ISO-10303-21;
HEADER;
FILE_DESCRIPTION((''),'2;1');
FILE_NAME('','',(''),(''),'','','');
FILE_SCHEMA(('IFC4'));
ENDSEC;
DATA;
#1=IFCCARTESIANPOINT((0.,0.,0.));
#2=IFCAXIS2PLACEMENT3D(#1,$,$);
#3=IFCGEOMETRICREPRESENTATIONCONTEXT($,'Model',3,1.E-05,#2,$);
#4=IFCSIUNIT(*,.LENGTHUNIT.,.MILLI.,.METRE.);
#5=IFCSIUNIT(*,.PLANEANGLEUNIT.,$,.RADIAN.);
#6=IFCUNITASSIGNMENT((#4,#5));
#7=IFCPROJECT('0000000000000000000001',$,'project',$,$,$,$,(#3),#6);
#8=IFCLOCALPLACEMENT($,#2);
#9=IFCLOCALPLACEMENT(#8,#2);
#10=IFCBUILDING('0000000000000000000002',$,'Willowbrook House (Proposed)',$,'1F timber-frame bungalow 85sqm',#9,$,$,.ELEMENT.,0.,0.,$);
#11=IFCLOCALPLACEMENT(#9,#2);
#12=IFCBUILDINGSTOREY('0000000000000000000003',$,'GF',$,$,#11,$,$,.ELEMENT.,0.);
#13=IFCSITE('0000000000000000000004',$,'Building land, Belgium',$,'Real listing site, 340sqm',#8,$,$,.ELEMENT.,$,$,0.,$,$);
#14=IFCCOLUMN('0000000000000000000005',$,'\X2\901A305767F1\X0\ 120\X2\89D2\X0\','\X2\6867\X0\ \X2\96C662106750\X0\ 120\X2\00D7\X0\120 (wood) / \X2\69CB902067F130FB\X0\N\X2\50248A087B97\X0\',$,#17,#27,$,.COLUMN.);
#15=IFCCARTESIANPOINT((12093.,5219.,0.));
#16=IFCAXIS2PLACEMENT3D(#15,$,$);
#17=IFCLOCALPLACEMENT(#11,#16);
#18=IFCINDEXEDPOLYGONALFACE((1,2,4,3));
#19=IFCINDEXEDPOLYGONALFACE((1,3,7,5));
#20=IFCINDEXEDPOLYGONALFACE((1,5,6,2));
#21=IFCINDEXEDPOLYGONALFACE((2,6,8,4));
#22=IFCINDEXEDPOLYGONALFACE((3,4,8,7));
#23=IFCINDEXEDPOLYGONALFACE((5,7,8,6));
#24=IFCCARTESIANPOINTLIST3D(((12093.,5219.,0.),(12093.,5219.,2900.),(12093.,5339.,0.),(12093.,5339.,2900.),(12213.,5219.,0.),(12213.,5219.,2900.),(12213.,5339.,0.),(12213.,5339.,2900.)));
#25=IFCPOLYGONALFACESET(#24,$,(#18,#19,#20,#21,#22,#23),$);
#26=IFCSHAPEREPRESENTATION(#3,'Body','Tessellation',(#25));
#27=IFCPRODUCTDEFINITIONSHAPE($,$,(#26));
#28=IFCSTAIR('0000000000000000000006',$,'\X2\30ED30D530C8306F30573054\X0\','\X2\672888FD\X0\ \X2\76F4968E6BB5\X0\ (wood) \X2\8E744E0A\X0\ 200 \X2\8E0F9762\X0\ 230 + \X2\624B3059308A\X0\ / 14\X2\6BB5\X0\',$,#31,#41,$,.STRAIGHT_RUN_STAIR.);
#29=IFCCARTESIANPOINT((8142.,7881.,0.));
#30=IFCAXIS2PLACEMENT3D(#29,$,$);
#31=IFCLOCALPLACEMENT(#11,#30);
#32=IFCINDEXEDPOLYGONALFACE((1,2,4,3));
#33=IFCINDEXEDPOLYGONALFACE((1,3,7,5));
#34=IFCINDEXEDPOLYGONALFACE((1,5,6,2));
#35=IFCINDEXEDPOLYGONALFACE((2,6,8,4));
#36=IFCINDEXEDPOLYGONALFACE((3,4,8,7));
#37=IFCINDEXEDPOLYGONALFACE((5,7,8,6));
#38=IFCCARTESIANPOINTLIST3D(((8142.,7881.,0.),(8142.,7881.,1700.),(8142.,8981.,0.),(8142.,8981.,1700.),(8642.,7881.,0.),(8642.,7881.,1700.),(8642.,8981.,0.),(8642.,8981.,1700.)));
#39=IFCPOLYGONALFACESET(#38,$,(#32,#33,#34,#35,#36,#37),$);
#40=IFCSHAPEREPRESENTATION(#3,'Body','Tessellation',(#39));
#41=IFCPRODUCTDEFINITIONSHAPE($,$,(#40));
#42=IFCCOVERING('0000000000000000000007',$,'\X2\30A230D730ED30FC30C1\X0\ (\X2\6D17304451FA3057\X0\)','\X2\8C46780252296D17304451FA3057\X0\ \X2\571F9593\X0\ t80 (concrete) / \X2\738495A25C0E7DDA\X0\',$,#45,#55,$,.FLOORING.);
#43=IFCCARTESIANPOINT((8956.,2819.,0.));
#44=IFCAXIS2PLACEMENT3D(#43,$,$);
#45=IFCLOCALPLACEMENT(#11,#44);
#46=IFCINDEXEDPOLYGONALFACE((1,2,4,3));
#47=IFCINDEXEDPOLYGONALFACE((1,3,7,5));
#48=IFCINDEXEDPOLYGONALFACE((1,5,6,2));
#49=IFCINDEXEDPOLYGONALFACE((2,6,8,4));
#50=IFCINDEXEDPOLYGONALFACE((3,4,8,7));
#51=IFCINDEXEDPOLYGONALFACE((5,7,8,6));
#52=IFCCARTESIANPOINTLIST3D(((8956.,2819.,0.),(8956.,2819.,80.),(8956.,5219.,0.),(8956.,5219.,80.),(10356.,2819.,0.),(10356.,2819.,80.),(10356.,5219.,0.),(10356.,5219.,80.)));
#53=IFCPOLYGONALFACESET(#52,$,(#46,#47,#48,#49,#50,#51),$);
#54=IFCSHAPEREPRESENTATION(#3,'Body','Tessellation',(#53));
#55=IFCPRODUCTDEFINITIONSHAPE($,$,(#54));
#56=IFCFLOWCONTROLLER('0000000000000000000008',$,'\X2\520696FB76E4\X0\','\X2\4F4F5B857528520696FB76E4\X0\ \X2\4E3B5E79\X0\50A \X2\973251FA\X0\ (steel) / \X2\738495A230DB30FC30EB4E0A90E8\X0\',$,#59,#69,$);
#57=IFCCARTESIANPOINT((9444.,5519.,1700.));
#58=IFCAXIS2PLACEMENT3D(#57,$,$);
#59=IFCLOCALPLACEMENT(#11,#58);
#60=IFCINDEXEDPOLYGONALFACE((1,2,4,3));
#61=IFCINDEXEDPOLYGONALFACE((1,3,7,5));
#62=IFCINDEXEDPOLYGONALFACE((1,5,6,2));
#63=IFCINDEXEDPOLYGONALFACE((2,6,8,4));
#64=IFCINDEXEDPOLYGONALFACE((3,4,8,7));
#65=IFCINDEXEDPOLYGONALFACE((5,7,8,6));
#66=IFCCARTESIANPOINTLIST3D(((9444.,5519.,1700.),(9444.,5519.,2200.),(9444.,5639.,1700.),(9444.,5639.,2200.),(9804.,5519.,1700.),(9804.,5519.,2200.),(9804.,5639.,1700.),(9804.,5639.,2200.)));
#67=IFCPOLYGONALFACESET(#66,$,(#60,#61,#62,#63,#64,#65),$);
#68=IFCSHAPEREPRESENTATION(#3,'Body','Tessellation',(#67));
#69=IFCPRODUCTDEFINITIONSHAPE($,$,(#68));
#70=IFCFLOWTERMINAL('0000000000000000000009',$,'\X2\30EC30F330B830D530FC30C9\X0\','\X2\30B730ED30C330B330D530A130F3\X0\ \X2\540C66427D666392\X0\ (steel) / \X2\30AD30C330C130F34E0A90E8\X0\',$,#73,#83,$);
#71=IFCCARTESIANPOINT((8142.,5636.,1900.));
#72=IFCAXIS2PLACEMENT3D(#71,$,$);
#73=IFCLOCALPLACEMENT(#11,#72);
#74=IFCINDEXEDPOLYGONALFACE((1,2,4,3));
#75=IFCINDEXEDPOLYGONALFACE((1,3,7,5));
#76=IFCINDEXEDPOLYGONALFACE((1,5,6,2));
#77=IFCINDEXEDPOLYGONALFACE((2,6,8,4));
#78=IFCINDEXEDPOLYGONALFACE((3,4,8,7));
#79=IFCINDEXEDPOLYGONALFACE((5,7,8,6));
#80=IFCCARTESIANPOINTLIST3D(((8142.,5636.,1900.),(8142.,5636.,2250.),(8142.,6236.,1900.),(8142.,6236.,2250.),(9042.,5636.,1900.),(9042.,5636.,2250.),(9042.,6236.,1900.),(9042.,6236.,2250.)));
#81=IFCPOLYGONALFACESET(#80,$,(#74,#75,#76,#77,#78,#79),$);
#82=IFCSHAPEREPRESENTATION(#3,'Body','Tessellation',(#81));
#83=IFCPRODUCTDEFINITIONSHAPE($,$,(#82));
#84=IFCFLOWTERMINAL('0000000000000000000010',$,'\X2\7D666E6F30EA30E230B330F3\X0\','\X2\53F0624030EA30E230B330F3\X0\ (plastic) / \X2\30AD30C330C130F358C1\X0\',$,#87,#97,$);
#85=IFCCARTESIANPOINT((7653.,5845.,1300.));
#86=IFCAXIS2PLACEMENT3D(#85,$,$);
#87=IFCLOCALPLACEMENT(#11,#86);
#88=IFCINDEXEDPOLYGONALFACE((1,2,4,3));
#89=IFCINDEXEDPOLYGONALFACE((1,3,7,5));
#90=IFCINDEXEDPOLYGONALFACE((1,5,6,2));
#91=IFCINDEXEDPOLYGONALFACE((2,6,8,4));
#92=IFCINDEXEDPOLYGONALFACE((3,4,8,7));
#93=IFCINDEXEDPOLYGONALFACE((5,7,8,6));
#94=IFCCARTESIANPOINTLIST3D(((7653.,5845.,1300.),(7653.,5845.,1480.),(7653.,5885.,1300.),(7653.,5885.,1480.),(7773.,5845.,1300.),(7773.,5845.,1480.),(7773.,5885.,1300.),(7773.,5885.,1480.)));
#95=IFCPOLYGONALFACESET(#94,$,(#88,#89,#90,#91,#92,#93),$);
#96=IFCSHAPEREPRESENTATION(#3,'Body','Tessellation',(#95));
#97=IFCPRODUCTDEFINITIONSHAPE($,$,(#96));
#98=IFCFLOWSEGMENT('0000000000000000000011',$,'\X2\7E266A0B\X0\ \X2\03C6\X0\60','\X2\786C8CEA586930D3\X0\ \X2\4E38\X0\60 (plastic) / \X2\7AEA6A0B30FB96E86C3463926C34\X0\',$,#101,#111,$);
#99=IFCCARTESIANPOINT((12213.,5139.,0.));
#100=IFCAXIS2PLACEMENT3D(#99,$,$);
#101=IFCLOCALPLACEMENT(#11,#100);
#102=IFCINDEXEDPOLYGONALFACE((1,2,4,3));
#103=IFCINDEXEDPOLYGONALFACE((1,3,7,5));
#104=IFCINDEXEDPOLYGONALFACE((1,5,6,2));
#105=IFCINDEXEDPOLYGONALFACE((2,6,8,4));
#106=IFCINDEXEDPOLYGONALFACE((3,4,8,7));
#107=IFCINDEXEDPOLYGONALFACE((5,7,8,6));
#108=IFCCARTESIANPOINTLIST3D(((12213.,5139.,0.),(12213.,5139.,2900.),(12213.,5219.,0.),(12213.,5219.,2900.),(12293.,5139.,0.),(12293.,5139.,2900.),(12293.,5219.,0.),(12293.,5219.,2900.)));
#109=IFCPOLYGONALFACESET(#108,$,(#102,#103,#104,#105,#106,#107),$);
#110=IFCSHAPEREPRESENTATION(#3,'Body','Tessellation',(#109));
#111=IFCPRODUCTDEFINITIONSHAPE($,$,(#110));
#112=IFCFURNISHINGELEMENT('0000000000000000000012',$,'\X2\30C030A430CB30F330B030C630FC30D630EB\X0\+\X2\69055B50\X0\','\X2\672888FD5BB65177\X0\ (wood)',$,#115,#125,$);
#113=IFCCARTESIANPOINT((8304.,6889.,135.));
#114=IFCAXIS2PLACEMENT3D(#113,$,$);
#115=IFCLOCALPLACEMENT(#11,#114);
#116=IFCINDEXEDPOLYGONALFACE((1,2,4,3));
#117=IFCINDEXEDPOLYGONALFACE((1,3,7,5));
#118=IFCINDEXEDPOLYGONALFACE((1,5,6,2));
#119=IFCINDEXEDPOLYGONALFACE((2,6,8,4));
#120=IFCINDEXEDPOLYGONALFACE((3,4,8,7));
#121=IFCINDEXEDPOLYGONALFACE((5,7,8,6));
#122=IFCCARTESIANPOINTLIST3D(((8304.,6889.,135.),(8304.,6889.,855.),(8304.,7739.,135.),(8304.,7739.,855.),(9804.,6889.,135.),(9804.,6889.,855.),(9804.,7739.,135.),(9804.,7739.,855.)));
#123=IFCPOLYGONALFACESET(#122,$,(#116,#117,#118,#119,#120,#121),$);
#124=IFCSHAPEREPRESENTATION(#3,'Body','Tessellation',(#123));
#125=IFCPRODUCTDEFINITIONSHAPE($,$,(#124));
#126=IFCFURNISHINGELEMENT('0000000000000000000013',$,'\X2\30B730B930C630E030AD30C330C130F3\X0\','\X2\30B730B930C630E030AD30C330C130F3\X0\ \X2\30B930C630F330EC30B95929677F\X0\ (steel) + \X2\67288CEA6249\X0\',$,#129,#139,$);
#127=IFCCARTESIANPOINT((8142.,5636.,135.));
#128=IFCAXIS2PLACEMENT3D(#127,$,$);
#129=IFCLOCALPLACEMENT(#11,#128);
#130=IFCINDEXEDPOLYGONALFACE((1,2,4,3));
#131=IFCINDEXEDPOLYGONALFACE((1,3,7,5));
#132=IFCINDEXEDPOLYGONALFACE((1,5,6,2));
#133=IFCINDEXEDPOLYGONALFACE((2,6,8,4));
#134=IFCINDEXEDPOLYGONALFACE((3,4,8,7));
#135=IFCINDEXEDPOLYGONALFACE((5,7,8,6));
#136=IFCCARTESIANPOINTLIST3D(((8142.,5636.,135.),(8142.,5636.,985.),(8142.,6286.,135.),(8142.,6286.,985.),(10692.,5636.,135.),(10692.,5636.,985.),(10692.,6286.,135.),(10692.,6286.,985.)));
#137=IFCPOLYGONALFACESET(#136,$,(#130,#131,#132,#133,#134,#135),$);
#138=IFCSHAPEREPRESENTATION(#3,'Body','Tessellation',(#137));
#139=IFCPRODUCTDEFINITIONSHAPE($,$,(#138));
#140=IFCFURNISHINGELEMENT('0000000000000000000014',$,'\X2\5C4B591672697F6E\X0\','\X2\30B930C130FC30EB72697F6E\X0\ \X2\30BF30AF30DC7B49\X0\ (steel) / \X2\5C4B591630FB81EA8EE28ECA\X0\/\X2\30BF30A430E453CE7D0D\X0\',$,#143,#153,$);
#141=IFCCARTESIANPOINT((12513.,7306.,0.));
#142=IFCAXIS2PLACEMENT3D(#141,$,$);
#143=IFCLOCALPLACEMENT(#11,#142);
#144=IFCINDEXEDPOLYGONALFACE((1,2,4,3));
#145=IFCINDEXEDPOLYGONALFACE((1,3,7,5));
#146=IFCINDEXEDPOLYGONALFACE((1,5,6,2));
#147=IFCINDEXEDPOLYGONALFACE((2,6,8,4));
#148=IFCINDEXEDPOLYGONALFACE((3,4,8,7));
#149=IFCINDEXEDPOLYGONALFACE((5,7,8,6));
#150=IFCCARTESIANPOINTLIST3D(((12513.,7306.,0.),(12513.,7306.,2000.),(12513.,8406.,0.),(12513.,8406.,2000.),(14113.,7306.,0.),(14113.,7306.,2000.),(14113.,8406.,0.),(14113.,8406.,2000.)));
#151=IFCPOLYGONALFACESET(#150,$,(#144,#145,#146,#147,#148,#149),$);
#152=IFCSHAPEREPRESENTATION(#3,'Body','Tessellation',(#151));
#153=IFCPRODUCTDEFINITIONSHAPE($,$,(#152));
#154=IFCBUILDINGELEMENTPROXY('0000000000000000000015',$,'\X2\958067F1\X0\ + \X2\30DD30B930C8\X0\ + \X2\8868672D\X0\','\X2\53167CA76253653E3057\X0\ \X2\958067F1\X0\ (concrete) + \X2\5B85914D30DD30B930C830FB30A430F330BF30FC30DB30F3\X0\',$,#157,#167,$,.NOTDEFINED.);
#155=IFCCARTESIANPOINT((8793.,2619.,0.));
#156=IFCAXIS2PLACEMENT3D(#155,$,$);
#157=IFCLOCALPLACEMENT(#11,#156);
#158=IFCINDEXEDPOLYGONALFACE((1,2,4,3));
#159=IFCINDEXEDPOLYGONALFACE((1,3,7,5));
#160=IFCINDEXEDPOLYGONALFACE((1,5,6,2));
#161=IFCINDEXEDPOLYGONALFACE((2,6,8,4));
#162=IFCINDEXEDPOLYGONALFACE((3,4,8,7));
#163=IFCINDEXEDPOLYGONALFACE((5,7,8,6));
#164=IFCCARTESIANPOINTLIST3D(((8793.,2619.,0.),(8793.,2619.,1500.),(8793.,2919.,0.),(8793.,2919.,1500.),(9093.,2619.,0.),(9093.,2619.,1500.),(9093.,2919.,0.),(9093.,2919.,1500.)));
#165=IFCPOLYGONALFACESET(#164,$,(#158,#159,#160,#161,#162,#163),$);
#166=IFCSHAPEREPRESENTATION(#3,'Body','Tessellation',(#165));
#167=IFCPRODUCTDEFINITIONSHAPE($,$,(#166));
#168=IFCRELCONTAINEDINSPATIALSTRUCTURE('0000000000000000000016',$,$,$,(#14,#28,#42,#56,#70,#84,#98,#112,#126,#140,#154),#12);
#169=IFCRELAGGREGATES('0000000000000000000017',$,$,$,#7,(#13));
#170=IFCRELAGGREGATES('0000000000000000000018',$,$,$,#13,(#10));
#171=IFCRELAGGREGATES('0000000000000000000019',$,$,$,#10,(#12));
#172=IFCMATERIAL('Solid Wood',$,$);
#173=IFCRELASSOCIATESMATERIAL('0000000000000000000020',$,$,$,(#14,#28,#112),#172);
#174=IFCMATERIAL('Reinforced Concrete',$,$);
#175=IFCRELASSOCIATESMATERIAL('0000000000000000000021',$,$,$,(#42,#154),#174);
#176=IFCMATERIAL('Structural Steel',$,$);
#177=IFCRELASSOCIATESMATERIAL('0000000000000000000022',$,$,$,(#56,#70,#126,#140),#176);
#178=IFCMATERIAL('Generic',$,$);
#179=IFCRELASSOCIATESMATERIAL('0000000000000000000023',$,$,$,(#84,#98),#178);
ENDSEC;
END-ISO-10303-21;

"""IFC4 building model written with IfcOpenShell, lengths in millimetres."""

from ifc_helpers import new_model, si_unit, frame, frame_2d, origin, place, context, project, spatial, rectangle, extrude, material, element, save


model = new_model("IFC4")

# Units and contexts
model_context = context("Model", 3, precision=1e-05, world=origin())
ifc_project = project(units=[si_unit("LENGTHUNIT", "METRE", prefix="MILLI"), si_unit("PLANEANGLEUNIT", "RADIAN")], contexts=[model_context])

# Site, building, storey
site_placement = place(None, origin())
site = spatial("IfcSite", under=ifc_project, at=site_placement, Name="Building land, Belgium", ObjectType="Real listing site, 340sqm", CompositionType="ELEMENT", RefElevation=0.0)
building_placement = place(site_placement, origin())
building = spatial("IfcBuilding", under=site, at=building_placement, Name="Willowbrook House (Proposed)", ObjectType="1F timber-frame bungalow 85sqm", CompositionType="ELEMENT", ElevationOfRefHeight=0.0, ElevationOfTerrain=0.0)
storey_placement = place(building_placement, origin())
storey = spatial("IfcBuildingStorey", under=building, at=storey_placement, Name="GF", CompositionType="ELEMENT", Elevation=0.0)

# Column
ifc_material_1 = material(Name="Solid Wood")
column_1_placement = place(storey_placement, frame((12093.0, 5219.0, 0.0)))
element("IfcColumn", 1, at=column_1_placement, inside=storey, material=ifc_material_1, Name="通し柱 120角", Description="桧 集成材 120×120 (wood) / 構造柱・N値計算", PredefinedType="COLUMN", context=model_context, shape_type="SweptSolid", body=[
    extrude(rectangle(XDim=120.0, YDim=120.0, at=frame_2d((60.0, 60.0))), frame((12093.0, 5219.0, 0.0)), (0.0, 0.0, 1.0), 2900.0),
])

# Stair
stair_placement = place(storey_placement, frame((8142.0, 7881.0, 0.0)))
element("IfcStair", 2, at=stair_placement, inside=storey, material=ifc_material_1, Name="ロフトはしご", Description="木製 直階段 (wood) 蹴上 200 踏面 230 + 手すり / 14段", PredefinedType="STRAIGHT_RUN_STAIR", context=model_context, shape_type="SweptSolid", body=[
    extrude(rectangle(XDim=500.0, YDim=1100.0, at=frame_2d((250.0, 550.0))), frame((8142.0, 7881.0, 0.0)), (0.0, 0.0, 1.0), 1700.0),
])

# Covering
ifc_material_2 = material(Name="Reinforced Concrete")
covering_placement = place(storey_placement, frame((8956.0, 2819.0, 0.0)))
element("IfcCovering", 3, at=covering_placement, inside=storey, material=ifc_material_2, Name="アプローチ (洗い出し)", Description="豆砂利洗い出し 土間 t80 (concrete) / 玄関導線", PredefinedType="FLOORING", context=model_context, shape_type="SweptSolid", body=[
    extrude(rectangle(XDim=1400.0, YDim=2400.0, at=frame_2d((700.0, 1200.0))), frame((8956.0, 2819.0, 0.0)), (0.0, 0.0, 1.0), 80.0),
])

# Flow controller
ifc_material_3 = material(Name="Structural Steel")
flow_controller_placement = place(storey_placement, frame((9444.0, 5519.0, 1700.0)))
element("IfcFlowController", 4, at=flow_controller_placement, inside=storey, material=ifc_material_3, Name="分電盤", Description="住宅用分電盤 主幹50A 露出 (steel) / 玄関ホール上部", context=model_context, shape_type="SweptSolid", body=[
    extrude(rectangle(XDim=360.0, YDim=120.0, at=frame_2d((180.0, 60.0))), frame((9444.0, 5519.0, 1700.0)), (0.0, 0.0, 1.0), 500.0),
])

# Flow terminals
flow_terminal_1_placement = place(storey_placement, frame((8142.0, 5636.0, 1900.0)))
element("IfcFlowTerminal", 5, at=flow_terminal_1_placement, inside=storey, material=ifc_material_3, Name="レンジフード", Description="シロッコファン 同時給排 (steel) / キッチン上部", context=model_context, shape_type="SweptSolid", body=[
    extrude(rectangle(XDim=900.0, YDim=600.0, at=frame_2d((450.0, 300.0))), frame((8142.0, 5636.0, 1900.0)), (0.0, 0.0, 1.0), 350.0),
])
ifc_material_4 = material(Name="Generic")
flow_terminal_2_placement = place(storey_placement, frame((7653.0, 5845.0, 1300.0)))
element("IfcFlowTerminal", 6, at=flow_terminal_2_placement, inside=storey, material=ifc_material_4, Name="給湯リモコン", Description="台所リモコン (plastic) / キッチン壁", context=model_context, shape_type="SweptSolid", body=[
    extrude(rectangle(XDim=120.0, YDim=40.0, at=frame_2d((60.0, 20.0))), frame((7653.0, 5845.0, 1300.0)), (0.0, 0.0, 1.0), 180.0),
])

# Flow segment
flow_segment_placement = place(storey_placement, frame((12213.0, 5139.0, 0.0)))
element("IfcFlowSegment", 7, at=flow_segment_placement, inside=storey, material=ifc_material_4, Name="縦樋 φ60", Description="硬質塩ビ 丸60 (plastic) / 竪樋・雨水排水", context=model_context, shape_type="SweptSolid", body=[
    extrude(rectangle(XDim=80.0, YDim=80.0, at=frame_2d((40.0, 40.0))), frame((12213.0, 5139.0, 0.0)), (0.0, 0.0, 1.0), 2900.0),
])

# Furnishing elements
furnishing_1_placement = place(storey_placement, frame((8304.0, 6889.0, 135.0)))
element("IfcFurnishingElement", 8, at=furnishing_1_placement, inside=storey, material=ifc_material_1, Name="ダイニングテーブル+椅子", Description="木製家具 (wood)", context=model_context, shape_type="SweptSolid", body=[
    extrude(rectangle(XDim=1500.0, YDim=850.0, at=frame_2d((750.0, 425.0))), frame((8304.0, 6889.0, 135.0)), (0.0, 0.0, 1.0), 720.0),
])
furnishing_2_placement = place(storey_placement, frame((8142.0, 5636.0, 135.0)))
element("IfcFurnishingElement", 9, at=furnishing_2_placement, inside=storey, material=ifc_material_3, Name="システムキッチン", Description="システムキッチン ステンレス天板 (steel) + 木質扉", context=model_context, shape_type="SweptSolid", body=[
    extrude(rectangle(XDim=2550.0, YDim=650.0, at=frame_2d((1275.0, 325.0))), frame((8142.0, 5636.0, 135.0)), (0.0, 0.0, 1.0), 850.0),
])
furnishing_3_placement = place(storey_placement, frame((12513.0, 7306.0, 0.0)))
element("IfcFurnishingElement", 10, at=furnishing_3_placement, inside=storey, material=ifc_material_3, Name="屋外物置", Description="スチール物置 タクボ等 (steel) / 屋外・自転車/タイヤ収納", context=model_context, shape_type="SweptSolid", body=[
    extrude(rectangle(XDim=1600.0, YDim=1100.0, at=frame_2d((800.0, 550.0))), frame((12513.0, 7306.0, 0.0)), (0.0, 0.0, 1.0), 2000.0),
])

# Building element proxy
proxy_placement = place(storey_placement, frame((8793.0, 2619.0, 0.0)))
element("IfcBuildingElementProxy", 11, at=proxy_placement, inside=storey, material=ifc_material_2, Name="門柱 + ポスト + 表札", Description="化粧打放し 門柱 (concrete) + 宅配ポスト・インターホン", PredefinedType="NOTDEFINED", context=model_context, shape_type="SweptSolid", body=[
    extrude(rectangle(XDim=300.0, YDim=300.0, at=frame_2d((150.0, 150.0))), frame((8793.0, 2619.0, 0.0)), (0.0, 0.0, 1.0), 1500.0),
])

save(model, "model.ifc")
